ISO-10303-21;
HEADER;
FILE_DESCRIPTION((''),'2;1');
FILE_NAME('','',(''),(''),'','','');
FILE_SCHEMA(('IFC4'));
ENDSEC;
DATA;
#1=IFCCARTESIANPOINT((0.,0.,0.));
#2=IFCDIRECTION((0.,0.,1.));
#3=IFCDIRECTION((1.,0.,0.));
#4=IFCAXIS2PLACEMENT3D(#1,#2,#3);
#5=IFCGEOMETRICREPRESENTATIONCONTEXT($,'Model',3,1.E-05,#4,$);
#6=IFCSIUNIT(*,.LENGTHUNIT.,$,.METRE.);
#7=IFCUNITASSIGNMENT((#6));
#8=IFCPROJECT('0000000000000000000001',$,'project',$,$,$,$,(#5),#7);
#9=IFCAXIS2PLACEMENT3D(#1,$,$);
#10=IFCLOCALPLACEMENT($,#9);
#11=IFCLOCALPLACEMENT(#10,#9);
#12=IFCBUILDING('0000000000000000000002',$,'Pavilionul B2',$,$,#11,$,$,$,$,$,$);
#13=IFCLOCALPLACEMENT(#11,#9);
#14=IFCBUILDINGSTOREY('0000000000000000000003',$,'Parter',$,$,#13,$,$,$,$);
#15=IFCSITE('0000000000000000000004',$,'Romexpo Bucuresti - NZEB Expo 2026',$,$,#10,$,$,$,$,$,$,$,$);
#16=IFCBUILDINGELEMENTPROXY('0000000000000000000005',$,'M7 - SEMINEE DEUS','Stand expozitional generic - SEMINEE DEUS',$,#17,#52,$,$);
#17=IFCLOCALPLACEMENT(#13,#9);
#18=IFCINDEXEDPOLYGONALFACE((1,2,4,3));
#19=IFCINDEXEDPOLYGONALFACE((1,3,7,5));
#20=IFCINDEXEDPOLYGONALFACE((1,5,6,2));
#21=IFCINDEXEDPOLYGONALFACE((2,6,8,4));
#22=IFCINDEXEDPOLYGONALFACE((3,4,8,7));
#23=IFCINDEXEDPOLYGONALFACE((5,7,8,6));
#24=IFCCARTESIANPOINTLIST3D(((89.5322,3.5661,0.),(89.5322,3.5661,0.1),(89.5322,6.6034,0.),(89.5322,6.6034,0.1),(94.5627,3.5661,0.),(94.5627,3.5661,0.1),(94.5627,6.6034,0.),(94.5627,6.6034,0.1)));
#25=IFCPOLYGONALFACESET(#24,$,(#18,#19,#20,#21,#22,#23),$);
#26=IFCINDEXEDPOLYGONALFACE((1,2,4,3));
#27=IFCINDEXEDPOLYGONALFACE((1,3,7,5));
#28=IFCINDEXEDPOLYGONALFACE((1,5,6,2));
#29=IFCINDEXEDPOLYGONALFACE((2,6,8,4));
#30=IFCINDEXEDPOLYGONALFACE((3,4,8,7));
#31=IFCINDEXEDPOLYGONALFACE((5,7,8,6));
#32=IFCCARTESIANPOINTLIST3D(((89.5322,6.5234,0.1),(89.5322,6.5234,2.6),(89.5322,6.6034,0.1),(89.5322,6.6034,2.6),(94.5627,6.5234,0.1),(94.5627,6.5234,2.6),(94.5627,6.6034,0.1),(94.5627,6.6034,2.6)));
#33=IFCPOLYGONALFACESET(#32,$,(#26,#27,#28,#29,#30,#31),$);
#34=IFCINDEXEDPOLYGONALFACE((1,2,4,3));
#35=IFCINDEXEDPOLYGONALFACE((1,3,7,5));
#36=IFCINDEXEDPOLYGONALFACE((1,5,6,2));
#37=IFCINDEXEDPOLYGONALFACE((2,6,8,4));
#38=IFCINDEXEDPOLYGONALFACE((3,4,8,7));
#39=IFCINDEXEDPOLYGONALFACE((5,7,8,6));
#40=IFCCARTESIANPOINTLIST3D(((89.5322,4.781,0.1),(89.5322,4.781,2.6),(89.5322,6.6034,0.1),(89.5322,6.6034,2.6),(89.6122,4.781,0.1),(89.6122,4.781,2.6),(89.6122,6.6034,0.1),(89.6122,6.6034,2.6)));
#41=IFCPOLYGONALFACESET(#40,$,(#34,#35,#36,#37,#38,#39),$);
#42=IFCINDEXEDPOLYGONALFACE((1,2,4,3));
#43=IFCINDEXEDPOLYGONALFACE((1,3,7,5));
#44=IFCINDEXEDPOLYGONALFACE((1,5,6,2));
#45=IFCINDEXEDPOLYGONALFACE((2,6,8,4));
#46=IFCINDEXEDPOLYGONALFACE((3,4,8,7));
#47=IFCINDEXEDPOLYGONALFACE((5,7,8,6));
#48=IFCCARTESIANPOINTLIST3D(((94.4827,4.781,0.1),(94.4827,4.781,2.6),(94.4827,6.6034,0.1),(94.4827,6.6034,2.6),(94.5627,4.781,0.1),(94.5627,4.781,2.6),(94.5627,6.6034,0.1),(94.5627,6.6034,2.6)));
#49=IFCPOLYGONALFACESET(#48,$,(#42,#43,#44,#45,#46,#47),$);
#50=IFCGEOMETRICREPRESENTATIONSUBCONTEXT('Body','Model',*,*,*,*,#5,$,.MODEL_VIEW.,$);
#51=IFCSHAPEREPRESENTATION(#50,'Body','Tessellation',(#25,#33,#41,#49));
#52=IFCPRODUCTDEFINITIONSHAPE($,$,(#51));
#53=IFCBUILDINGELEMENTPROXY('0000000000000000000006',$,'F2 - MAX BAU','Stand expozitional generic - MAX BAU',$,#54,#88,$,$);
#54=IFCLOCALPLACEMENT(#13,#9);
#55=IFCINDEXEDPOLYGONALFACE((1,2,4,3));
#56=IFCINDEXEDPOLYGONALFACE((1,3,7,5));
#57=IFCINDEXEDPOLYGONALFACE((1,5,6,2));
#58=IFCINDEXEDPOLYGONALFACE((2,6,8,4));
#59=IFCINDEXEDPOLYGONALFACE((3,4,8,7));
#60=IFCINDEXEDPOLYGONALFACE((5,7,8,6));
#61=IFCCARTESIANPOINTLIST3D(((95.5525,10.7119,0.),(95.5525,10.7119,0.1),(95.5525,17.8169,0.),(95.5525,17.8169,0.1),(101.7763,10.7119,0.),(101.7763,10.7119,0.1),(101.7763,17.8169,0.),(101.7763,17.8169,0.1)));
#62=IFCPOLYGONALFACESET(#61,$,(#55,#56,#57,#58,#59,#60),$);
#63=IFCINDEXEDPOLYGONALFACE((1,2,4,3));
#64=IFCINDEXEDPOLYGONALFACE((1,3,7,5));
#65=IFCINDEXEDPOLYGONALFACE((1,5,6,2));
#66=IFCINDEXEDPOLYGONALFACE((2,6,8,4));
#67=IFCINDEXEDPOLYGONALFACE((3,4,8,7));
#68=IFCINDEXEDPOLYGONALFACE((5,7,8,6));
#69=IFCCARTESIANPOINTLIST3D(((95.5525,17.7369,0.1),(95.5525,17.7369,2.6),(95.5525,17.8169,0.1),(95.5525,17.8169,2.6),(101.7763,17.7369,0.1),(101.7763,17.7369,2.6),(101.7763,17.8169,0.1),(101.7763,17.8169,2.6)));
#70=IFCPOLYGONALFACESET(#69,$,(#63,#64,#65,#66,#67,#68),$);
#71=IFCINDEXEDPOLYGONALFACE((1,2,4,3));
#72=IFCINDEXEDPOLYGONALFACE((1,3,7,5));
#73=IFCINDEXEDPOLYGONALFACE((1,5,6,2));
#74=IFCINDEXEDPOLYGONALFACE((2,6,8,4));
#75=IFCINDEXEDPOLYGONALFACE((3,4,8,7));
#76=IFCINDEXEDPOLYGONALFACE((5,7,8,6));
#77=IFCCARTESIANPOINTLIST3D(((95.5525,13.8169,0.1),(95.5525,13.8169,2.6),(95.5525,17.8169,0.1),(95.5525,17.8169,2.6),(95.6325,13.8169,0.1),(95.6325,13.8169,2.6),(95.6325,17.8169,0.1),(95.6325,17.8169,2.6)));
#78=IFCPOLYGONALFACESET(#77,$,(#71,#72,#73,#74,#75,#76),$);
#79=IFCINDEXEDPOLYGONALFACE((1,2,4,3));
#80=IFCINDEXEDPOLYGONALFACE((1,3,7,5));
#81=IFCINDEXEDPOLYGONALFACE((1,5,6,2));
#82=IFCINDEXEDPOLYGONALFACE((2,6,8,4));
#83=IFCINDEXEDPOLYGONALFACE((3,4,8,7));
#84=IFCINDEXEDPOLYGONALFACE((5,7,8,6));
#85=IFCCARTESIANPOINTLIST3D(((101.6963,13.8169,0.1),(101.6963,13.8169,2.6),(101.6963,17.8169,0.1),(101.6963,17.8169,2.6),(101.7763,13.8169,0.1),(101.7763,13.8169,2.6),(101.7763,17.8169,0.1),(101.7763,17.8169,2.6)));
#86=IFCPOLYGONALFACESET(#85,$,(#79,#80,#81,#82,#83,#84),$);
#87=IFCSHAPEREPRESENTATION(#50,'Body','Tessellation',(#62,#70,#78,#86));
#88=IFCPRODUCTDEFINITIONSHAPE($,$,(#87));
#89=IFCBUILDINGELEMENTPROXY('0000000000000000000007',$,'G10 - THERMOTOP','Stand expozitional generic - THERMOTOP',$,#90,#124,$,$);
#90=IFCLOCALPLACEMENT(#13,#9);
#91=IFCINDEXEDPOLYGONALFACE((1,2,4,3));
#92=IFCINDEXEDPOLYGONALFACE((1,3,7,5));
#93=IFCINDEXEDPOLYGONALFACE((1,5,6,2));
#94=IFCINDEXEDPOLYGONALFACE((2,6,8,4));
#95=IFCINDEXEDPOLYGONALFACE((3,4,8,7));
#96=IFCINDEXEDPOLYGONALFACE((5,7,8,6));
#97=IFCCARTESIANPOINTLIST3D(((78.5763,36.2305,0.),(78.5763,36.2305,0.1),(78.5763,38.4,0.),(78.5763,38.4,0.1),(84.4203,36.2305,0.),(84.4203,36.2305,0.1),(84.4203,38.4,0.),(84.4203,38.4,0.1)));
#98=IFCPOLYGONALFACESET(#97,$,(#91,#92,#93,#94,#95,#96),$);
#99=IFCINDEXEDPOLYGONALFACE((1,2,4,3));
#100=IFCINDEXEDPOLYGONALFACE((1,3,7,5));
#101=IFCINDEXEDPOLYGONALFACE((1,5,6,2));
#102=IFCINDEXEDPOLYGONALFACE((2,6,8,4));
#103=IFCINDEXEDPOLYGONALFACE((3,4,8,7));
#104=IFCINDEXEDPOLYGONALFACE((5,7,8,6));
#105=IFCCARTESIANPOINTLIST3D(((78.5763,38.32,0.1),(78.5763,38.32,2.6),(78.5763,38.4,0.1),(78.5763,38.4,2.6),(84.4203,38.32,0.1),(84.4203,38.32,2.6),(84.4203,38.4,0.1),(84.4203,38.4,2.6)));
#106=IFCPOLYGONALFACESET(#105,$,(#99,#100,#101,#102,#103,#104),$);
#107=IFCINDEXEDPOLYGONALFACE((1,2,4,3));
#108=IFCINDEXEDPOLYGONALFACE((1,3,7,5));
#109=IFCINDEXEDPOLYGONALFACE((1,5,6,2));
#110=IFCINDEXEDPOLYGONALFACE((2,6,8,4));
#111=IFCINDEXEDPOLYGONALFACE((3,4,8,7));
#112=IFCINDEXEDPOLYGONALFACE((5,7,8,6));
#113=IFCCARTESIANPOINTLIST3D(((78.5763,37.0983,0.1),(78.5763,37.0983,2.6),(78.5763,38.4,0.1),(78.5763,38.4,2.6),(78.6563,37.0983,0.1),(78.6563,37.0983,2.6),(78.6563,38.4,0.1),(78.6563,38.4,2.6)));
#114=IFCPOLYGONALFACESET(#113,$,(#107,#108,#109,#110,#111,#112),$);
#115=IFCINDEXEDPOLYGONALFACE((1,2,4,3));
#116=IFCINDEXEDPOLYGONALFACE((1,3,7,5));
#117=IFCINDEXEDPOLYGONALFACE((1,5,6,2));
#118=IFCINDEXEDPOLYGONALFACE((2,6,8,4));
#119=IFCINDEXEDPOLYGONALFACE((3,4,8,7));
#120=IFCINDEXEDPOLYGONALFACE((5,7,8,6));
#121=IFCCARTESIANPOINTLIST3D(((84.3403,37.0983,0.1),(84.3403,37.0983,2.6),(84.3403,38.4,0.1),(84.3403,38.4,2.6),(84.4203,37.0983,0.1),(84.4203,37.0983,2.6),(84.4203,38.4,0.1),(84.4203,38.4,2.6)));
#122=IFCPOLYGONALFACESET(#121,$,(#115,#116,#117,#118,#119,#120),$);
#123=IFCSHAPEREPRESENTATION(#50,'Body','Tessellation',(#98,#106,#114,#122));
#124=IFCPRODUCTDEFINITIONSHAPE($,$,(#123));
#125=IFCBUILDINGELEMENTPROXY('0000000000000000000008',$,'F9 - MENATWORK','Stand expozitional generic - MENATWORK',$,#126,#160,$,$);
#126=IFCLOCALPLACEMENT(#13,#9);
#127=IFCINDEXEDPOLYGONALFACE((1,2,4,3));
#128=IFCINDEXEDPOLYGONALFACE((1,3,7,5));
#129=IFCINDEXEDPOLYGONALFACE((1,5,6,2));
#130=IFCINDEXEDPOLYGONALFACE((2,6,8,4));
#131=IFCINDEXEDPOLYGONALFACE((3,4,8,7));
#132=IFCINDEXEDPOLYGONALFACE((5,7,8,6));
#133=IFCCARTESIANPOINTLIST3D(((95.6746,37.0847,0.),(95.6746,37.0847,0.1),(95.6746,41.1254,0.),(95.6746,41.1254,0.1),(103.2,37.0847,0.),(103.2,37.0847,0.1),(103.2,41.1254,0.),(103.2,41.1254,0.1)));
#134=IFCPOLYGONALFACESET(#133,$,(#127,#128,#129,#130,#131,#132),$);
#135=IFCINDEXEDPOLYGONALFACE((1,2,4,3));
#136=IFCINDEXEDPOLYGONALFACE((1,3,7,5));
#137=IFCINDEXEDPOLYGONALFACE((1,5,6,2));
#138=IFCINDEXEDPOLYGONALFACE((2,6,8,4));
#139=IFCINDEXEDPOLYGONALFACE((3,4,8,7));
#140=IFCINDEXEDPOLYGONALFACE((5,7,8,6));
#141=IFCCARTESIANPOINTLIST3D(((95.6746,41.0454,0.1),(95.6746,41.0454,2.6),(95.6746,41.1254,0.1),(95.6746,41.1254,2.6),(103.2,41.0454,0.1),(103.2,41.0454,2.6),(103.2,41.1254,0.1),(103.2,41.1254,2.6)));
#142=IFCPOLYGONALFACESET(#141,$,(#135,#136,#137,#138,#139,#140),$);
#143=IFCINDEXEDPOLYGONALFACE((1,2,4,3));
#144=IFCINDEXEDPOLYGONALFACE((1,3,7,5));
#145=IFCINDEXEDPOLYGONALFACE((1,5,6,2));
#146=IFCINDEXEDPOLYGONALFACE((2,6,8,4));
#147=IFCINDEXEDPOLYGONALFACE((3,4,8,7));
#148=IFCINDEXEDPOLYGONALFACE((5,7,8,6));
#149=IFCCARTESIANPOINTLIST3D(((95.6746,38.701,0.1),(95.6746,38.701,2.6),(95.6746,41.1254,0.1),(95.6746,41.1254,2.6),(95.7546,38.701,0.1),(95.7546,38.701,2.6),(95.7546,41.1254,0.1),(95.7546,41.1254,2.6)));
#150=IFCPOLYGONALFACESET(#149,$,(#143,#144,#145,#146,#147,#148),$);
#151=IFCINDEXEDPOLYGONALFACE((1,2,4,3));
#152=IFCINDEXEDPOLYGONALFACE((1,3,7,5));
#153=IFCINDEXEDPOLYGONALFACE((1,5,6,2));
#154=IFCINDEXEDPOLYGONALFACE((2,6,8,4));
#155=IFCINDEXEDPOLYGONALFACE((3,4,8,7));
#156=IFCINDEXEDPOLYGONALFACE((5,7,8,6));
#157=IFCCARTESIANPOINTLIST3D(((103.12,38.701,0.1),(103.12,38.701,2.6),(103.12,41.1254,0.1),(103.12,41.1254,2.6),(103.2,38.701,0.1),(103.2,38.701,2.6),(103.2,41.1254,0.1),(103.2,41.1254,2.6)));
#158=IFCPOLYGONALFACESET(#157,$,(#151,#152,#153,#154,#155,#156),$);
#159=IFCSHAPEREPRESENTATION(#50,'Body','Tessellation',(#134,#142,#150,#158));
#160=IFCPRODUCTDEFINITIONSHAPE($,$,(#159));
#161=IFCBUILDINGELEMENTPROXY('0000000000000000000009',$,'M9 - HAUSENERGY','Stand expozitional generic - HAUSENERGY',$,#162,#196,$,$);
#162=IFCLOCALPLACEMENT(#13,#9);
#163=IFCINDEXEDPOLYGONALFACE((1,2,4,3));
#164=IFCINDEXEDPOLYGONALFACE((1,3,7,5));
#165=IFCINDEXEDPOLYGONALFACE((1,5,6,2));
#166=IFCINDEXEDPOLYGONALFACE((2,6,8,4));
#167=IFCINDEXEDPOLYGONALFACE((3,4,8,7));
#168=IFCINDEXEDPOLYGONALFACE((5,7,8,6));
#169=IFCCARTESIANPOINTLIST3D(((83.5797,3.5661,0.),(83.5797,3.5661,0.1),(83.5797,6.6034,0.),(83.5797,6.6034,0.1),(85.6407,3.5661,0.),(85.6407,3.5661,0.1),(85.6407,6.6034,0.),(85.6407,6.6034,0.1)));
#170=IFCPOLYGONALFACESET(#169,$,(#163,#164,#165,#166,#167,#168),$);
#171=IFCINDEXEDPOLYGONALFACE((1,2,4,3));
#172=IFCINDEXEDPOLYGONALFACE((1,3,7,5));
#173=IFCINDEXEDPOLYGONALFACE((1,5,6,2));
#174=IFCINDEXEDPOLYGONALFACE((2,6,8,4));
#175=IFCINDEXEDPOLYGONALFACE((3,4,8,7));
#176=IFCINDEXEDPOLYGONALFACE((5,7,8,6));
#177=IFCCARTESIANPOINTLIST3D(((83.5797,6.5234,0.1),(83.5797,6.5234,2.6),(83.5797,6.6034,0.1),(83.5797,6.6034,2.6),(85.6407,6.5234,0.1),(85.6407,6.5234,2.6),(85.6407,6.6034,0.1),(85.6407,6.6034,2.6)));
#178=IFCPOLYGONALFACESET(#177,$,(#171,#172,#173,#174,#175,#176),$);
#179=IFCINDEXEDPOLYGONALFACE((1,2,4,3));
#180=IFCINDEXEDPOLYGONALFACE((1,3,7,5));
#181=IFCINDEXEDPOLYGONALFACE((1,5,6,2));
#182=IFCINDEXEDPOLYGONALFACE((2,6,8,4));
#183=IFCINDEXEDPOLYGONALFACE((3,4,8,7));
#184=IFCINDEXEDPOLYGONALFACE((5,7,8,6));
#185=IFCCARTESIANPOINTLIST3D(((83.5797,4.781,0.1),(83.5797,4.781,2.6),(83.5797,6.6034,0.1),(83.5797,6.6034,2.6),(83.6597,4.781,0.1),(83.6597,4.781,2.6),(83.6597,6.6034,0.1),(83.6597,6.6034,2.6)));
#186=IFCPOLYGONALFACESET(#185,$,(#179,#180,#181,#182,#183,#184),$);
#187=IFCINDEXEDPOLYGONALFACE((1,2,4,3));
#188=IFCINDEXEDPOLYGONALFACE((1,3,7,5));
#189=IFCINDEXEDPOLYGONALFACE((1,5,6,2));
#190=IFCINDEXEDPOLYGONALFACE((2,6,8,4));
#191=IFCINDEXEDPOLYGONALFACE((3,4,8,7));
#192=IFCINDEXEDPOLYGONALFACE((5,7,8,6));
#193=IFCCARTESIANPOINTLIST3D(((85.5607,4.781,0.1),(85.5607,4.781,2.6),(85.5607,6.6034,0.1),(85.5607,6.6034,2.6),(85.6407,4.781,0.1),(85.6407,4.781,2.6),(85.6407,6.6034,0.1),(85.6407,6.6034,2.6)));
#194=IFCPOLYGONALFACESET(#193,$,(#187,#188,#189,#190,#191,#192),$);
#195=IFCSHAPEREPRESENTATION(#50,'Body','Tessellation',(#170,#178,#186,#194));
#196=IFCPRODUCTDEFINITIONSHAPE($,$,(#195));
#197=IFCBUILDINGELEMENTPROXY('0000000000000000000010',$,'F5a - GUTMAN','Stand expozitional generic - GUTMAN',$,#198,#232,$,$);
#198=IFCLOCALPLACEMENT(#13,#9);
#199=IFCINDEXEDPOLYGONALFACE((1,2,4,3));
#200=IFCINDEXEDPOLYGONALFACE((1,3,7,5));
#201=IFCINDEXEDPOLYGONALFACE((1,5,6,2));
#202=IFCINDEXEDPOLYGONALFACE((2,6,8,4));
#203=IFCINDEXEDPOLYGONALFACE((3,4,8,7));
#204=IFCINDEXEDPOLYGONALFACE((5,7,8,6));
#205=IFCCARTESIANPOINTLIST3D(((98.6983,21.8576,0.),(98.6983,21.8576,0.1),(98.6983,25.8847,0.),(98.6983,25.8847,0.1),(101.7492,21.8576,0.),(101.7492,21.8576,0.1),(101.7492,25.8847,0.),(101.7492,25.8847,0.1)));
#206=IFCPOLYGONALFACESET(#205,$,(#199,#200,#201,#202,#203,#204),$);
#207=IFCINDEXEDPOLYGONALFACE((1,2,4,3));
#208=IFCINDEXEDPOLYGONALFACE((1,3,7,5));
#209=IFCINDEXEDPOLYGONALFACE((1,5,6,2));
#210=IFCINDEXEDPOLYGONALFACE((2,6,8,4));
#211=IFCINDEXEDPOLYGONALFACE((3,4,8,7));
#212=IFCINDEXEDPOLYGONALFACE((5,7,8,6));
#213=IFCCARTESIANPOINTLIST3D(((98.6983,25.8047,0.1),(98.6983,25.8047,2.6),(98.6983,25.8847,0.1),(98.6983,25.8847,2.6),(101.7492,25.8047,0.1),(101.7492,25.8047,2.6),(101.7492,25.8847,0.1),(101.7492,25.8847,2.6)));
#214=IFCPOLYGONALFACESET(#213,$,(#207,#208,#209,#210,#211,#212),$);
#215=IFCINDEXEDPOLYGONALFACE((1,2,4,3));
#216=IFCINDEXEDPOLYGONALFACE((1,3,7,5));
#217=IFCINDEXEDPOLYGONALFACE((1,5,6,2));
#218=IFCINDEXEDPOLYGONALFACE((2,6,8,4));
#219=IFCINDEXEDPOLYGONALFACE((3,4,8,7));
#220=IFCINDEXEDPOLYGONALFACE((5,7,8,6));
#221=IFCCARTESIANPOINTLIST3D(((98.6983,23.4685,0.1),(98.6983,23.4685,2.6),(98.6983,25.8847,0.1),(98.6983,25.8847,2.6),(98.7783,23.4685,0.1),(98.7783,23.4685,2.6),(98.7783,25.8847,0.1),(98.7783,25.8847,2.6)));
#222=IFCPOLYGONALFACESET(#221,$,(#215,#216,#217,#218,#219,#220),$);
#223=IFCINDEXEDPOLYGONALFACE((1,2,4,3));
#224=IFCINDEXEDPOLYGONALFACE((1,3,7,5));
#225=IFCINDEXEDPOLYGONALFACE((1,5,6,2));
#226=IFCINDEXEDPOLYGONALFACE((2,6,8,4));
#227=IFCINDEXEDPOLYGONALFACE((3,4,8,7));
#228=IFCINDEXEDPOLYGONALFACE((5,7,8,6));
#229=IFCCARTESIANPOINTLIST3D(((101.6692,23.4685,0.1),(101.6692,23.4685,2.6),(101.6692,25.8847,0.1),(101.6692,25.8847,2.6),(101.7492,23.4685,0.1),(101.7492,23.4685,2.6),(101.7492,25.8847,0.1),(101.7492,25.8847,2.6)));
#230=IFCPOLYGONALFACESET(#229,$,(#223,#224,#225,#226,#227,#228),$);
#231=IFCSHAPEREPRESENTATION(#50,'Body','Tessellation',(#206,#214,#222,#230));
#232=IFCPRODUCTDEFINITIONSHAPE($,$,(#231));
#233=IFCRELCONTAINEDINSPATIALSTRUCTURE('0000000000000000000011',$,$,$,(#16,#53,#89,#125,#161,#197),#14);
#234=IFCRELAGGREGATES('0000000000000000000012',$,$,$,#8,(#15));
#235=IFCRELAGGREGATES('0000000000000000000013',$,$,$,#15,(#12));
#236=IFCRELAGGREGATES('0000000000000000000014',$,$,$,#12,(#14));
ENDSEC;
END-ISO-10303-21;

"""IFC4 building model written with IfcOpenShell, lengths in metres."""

from ifc_helpers import new_model, si_unit, frame, frame_2d, origin, origin_with_axes, place, context, subcontext, project, spatial, rectangle, extrude, element, save


model = new_model("IFC4")

# Units and contexts
model_context = context("Model", 3, precision=1e-05, world=origin_with_axes())
body_context = subcontext(model_context, "Body", "Model", "MODEL_VIEW")
ifc_project = project(units=[si_unit("LENGTHUNIT", "METRE")], contexts=[model_context])

# Site, building, storey
site_placement = place(None, origin())
site = spatial("IfcSite", under=ifc_project, at=site_placement, Name="Romexpo Bucuresti - NZEB Expo 2026")
building_placement = place(site_placement, origin())
building = spatial("IfcBuilding", under=site, at=building_placement, Name="Pavilionul B2")
storey_placement = place(building_placement, origin())
storey = spatial("IfcBuildingStorey", under=building, at=storey_placement, Name="Parter")

# Building element proxies
proxy_1_placement = place(storey_placement, frame((89.5322, 3.5661, 0.0), z_axis=(0.0, 0.0, 1.0), x_axis=(1.0, 0.0, 0.0)))
element("IfcBuildingElementProxy", 1, at=proxy_1_placement, inside=storey, Name="M7 - SEMINEE DEUS", Description="Stand expozitional generic - SEMINEE DEUS", context=body_context, shape_type="SweptSolid", body=[
    extrude(rectangle(XDim=5.0305, YDim=3.0373, at=frame_2d((2.5153, 1.5186))), origin(), (0.0, 0.0, 1.0), 0.1),
    extrude(rectangle(XDim=5.0305, YDim=0.08, at=frame_2d((2.5153, 2.9973))), frame((0.0, 0.0, 0.1)), (0.0, 0.0, 1.0), 2.5),
    extrude(rectangle(XDim=0.08, YDim=1.8224, at=frame_2d((0.04, 2.1261))), frame((0.0, 0.0, 0.1)), (0.0, 0.0, 1.0), 2.5),
    extrude(rectangle(XDim=0.08, YDim=1.8224, at=frame_2d((4.9905, 2.1261))), frame((0.0, 0.0, 0.1)), (0.0, 0.0, 1.0), 2.5),
])
proxy_2_placement = place(storey_placement, frame((95.5525, 10.7119, 0.0), z_axis=(0.0, 0.0, 1.0), x_axis=(1.0, 0.0, 0.0)))
element("IfcBuildingElementProxy", 2, at=proxy_2_placement, inside=storey, Name="F2 - MAX BAU", Description="Stand expozitional generic - MAX BAU", context=body_context, shape_type="SweptSolid", body=[
    extrude(rectangle(XDim=6.2237, YDim=7.1051, at=frame_2d((3.1119, 3.5525))), origin(), (0.0, 0.0, 1.0), 0.1),
    extrude(rectangle(XDim=6.2237, YDim=0.08, at=frame_2d((3.1119, 7.0651))), frame((0.0, 0.0, 0.1)), (0.0, 0.0, 1.0), 2.5),
    extrude(rectangle(XDim=0.08, YDim=4.0, at=frame_2d((0.04, 5.1051))), frame((0.0, 0.0, 0.1)), (0.0, 0.0, 1.0), 2.5),
    extrude(rectangle(XDim=0.08, YDim=4.0, at=frame_2d((6.1837, 5.1051))), frame((0.0, 0.0, 0.1)), (0.0, 0.0, 1.0), 2.5),
])
proxy_3_placement = place(storey_placement, frame((78.5763, 36.2305, 0.0), z_axis=(0.0, 0.0, 1.0), x_axis=(1.0, 0.0, 0.0)))
element("IfcBuildingElementProxy", 3, at=proxy_3_placement, inside=storey, Name="G10 - THERMOTOP", Description="Stand expozitional generic - THERMOTOP", context=body_context, shape_type="SweptSolid", body=[
    extrude(rectangle(XDim=5.8441, YDim=2.1695, at=frame_2d((2.922, 1.0847))), origin(), (0.0, 0.0, 1.0), 0.1),
    extrude(rectangle(XDim=5.8441, YDim=0.08, at=frame_2d((2.922, 2.1295))), frame((0.0, 0.0, 0.1)), (0.0, 0.0, 1.0), 2.5),
    extrude(rectangle(XDim=0.08, YDim=1.3017, at=frame_2d((0.04, 1.5186))), frame((0.0, 0.0, 0.1)), (0.0, 0.0, 1.0), 2.5),
    extrude(rectangle(XDim=0.08, YDim=1.3017, at=frame_2d((5.8041, 1.5186))), frame((0.0, 0.0, 0.1)), (0.0, 0.0, 1.0), 2.5),
])
proxy_4_placement = place(storey_placement, frame((95.6746, 37.0847, 0.0), z_axis=(0.0, 0.0, 1.0), x_axis=(1.0, 0.0, 0.0)))
element("IfcBuildingElementProxy", 4, at=proxy_4_placement, inside=storey, Name="F9 - MENATWORK", Description="Stand expozitional generic - MENATWORK", context=body_context, shape_type="SweptSolid", body=[
    extrude(rectangle(XDim=7.5254, YDim=4.0407, at=frame_2d((3.7627, 2.0203))), origin(), (0.0, 0.0, 1.0), 0.1),
    extrude(rectangle(XDim=7.5254, YDim=0.08, at=frame_2d((3.7627, 4.0007))), frame((0.0, 0.0, 0.1)), (0.0, 0.0, 1.0), 2.5),
    extrude(rectangle(XDim=0.08, YDim=2.4244, at=frame_2d((0.04, 2.8285))), frame((0.0, 0.0, 0.1)), (0.0, 0.0, 1.0), 2.5),
    extrude(rectangle(XDim=0.08, YDim=2.4244, at=frame_2d((7.4854, 2.8285))), frame((0.0, 0.0, 0.1)), (0.0, 0.0, 1.0), 2.5),
])
proxy_5_placement = place(storey_placement, frame((83.5797, 3.5661, 0.0), z_axis=(0.0, 0.0, 1.0), x_axis=(1.0, 0.0, 0.0)))
element("IfcBuildingElementProxy", 5, at=proxy_5_placement, inside=storey, Name="M9 - HAUSENERGY", Description="Stand expozitional generic - HAUSENERGY", context=body_context, shape_type="SweptSolid", body=[
    extrude(rectangle(XDim=2.061, YDim=3.0373, at=frame_2d((1.0305, 1.5186))), origin(), (0.0, 0.0, 1.0), 0.1),
    extrude(rectangle(XDim=2.061, YDim=0.08, at=frame_2d((1.0305, 2.9973))), frame((0.0, 0.0, 0.1)), (0.0, 0.0, 1.0), 2.5),
    extrude(rectangle(XDim=0.08, YDim=1.8224, at=frame_2d((0.04, 2.1261))), frame((0.0, 0.0, 0.1)), (0.0, 0.0, 1.0), 2.5),
    extrude(rectangle(XDim=0.08, YDim=1.8224, at=frame_2d((2.021, 2.1261))), frame((0.0, 0.0, 0.1)), (0.0, 0.0, 1.0), 2.5),
])
proxy_6_placement = place(storey_placement, frame((98.6983, 21.8576, 0.0), z_axis=(0.0, 0.0, 1.0), x_axis=(1.0, 0.0, 0.0)))
element("IfcBuildingElementProxy", 6, at=proxy_6_placement, inside=storey, Name="F5a - GUTMAN", Description="Stand expozitional generic - GUTMAN", context=body_context, shape_type="SweptSolid", body=[
    extrude(rectangle(XDim=3.0508, YDim=4.0271, at=frame_2d((1.5254, 2.0136))), origin(), (0.0, 0.0, 1.0), 0.1),
    extrude(rectangle(XDim=3.0508, YDim=0.08, at=frame_2d((1.5254, 3.9871))), frame((0.0, 0.0, 0.1)), (0.0, 0.0, 1.0), 2.5),
    extrude(rectangle(XDim=0.08, YDim=2.4163, at=frame_2d((0.04, 2.819))), frame((0.0, 0.0, 0.1)), (0.0, 0.0, 1.0), 2.5),
    extrude(rectangle(XDim=0.08, YDim=2.4163, at=frame_2d((3.0108, 2.819))), frame((0.0, 0.0, 0.1)), (0.0, 0.0, 1.0), 2.5),
])

save(model, "model.ifc")
